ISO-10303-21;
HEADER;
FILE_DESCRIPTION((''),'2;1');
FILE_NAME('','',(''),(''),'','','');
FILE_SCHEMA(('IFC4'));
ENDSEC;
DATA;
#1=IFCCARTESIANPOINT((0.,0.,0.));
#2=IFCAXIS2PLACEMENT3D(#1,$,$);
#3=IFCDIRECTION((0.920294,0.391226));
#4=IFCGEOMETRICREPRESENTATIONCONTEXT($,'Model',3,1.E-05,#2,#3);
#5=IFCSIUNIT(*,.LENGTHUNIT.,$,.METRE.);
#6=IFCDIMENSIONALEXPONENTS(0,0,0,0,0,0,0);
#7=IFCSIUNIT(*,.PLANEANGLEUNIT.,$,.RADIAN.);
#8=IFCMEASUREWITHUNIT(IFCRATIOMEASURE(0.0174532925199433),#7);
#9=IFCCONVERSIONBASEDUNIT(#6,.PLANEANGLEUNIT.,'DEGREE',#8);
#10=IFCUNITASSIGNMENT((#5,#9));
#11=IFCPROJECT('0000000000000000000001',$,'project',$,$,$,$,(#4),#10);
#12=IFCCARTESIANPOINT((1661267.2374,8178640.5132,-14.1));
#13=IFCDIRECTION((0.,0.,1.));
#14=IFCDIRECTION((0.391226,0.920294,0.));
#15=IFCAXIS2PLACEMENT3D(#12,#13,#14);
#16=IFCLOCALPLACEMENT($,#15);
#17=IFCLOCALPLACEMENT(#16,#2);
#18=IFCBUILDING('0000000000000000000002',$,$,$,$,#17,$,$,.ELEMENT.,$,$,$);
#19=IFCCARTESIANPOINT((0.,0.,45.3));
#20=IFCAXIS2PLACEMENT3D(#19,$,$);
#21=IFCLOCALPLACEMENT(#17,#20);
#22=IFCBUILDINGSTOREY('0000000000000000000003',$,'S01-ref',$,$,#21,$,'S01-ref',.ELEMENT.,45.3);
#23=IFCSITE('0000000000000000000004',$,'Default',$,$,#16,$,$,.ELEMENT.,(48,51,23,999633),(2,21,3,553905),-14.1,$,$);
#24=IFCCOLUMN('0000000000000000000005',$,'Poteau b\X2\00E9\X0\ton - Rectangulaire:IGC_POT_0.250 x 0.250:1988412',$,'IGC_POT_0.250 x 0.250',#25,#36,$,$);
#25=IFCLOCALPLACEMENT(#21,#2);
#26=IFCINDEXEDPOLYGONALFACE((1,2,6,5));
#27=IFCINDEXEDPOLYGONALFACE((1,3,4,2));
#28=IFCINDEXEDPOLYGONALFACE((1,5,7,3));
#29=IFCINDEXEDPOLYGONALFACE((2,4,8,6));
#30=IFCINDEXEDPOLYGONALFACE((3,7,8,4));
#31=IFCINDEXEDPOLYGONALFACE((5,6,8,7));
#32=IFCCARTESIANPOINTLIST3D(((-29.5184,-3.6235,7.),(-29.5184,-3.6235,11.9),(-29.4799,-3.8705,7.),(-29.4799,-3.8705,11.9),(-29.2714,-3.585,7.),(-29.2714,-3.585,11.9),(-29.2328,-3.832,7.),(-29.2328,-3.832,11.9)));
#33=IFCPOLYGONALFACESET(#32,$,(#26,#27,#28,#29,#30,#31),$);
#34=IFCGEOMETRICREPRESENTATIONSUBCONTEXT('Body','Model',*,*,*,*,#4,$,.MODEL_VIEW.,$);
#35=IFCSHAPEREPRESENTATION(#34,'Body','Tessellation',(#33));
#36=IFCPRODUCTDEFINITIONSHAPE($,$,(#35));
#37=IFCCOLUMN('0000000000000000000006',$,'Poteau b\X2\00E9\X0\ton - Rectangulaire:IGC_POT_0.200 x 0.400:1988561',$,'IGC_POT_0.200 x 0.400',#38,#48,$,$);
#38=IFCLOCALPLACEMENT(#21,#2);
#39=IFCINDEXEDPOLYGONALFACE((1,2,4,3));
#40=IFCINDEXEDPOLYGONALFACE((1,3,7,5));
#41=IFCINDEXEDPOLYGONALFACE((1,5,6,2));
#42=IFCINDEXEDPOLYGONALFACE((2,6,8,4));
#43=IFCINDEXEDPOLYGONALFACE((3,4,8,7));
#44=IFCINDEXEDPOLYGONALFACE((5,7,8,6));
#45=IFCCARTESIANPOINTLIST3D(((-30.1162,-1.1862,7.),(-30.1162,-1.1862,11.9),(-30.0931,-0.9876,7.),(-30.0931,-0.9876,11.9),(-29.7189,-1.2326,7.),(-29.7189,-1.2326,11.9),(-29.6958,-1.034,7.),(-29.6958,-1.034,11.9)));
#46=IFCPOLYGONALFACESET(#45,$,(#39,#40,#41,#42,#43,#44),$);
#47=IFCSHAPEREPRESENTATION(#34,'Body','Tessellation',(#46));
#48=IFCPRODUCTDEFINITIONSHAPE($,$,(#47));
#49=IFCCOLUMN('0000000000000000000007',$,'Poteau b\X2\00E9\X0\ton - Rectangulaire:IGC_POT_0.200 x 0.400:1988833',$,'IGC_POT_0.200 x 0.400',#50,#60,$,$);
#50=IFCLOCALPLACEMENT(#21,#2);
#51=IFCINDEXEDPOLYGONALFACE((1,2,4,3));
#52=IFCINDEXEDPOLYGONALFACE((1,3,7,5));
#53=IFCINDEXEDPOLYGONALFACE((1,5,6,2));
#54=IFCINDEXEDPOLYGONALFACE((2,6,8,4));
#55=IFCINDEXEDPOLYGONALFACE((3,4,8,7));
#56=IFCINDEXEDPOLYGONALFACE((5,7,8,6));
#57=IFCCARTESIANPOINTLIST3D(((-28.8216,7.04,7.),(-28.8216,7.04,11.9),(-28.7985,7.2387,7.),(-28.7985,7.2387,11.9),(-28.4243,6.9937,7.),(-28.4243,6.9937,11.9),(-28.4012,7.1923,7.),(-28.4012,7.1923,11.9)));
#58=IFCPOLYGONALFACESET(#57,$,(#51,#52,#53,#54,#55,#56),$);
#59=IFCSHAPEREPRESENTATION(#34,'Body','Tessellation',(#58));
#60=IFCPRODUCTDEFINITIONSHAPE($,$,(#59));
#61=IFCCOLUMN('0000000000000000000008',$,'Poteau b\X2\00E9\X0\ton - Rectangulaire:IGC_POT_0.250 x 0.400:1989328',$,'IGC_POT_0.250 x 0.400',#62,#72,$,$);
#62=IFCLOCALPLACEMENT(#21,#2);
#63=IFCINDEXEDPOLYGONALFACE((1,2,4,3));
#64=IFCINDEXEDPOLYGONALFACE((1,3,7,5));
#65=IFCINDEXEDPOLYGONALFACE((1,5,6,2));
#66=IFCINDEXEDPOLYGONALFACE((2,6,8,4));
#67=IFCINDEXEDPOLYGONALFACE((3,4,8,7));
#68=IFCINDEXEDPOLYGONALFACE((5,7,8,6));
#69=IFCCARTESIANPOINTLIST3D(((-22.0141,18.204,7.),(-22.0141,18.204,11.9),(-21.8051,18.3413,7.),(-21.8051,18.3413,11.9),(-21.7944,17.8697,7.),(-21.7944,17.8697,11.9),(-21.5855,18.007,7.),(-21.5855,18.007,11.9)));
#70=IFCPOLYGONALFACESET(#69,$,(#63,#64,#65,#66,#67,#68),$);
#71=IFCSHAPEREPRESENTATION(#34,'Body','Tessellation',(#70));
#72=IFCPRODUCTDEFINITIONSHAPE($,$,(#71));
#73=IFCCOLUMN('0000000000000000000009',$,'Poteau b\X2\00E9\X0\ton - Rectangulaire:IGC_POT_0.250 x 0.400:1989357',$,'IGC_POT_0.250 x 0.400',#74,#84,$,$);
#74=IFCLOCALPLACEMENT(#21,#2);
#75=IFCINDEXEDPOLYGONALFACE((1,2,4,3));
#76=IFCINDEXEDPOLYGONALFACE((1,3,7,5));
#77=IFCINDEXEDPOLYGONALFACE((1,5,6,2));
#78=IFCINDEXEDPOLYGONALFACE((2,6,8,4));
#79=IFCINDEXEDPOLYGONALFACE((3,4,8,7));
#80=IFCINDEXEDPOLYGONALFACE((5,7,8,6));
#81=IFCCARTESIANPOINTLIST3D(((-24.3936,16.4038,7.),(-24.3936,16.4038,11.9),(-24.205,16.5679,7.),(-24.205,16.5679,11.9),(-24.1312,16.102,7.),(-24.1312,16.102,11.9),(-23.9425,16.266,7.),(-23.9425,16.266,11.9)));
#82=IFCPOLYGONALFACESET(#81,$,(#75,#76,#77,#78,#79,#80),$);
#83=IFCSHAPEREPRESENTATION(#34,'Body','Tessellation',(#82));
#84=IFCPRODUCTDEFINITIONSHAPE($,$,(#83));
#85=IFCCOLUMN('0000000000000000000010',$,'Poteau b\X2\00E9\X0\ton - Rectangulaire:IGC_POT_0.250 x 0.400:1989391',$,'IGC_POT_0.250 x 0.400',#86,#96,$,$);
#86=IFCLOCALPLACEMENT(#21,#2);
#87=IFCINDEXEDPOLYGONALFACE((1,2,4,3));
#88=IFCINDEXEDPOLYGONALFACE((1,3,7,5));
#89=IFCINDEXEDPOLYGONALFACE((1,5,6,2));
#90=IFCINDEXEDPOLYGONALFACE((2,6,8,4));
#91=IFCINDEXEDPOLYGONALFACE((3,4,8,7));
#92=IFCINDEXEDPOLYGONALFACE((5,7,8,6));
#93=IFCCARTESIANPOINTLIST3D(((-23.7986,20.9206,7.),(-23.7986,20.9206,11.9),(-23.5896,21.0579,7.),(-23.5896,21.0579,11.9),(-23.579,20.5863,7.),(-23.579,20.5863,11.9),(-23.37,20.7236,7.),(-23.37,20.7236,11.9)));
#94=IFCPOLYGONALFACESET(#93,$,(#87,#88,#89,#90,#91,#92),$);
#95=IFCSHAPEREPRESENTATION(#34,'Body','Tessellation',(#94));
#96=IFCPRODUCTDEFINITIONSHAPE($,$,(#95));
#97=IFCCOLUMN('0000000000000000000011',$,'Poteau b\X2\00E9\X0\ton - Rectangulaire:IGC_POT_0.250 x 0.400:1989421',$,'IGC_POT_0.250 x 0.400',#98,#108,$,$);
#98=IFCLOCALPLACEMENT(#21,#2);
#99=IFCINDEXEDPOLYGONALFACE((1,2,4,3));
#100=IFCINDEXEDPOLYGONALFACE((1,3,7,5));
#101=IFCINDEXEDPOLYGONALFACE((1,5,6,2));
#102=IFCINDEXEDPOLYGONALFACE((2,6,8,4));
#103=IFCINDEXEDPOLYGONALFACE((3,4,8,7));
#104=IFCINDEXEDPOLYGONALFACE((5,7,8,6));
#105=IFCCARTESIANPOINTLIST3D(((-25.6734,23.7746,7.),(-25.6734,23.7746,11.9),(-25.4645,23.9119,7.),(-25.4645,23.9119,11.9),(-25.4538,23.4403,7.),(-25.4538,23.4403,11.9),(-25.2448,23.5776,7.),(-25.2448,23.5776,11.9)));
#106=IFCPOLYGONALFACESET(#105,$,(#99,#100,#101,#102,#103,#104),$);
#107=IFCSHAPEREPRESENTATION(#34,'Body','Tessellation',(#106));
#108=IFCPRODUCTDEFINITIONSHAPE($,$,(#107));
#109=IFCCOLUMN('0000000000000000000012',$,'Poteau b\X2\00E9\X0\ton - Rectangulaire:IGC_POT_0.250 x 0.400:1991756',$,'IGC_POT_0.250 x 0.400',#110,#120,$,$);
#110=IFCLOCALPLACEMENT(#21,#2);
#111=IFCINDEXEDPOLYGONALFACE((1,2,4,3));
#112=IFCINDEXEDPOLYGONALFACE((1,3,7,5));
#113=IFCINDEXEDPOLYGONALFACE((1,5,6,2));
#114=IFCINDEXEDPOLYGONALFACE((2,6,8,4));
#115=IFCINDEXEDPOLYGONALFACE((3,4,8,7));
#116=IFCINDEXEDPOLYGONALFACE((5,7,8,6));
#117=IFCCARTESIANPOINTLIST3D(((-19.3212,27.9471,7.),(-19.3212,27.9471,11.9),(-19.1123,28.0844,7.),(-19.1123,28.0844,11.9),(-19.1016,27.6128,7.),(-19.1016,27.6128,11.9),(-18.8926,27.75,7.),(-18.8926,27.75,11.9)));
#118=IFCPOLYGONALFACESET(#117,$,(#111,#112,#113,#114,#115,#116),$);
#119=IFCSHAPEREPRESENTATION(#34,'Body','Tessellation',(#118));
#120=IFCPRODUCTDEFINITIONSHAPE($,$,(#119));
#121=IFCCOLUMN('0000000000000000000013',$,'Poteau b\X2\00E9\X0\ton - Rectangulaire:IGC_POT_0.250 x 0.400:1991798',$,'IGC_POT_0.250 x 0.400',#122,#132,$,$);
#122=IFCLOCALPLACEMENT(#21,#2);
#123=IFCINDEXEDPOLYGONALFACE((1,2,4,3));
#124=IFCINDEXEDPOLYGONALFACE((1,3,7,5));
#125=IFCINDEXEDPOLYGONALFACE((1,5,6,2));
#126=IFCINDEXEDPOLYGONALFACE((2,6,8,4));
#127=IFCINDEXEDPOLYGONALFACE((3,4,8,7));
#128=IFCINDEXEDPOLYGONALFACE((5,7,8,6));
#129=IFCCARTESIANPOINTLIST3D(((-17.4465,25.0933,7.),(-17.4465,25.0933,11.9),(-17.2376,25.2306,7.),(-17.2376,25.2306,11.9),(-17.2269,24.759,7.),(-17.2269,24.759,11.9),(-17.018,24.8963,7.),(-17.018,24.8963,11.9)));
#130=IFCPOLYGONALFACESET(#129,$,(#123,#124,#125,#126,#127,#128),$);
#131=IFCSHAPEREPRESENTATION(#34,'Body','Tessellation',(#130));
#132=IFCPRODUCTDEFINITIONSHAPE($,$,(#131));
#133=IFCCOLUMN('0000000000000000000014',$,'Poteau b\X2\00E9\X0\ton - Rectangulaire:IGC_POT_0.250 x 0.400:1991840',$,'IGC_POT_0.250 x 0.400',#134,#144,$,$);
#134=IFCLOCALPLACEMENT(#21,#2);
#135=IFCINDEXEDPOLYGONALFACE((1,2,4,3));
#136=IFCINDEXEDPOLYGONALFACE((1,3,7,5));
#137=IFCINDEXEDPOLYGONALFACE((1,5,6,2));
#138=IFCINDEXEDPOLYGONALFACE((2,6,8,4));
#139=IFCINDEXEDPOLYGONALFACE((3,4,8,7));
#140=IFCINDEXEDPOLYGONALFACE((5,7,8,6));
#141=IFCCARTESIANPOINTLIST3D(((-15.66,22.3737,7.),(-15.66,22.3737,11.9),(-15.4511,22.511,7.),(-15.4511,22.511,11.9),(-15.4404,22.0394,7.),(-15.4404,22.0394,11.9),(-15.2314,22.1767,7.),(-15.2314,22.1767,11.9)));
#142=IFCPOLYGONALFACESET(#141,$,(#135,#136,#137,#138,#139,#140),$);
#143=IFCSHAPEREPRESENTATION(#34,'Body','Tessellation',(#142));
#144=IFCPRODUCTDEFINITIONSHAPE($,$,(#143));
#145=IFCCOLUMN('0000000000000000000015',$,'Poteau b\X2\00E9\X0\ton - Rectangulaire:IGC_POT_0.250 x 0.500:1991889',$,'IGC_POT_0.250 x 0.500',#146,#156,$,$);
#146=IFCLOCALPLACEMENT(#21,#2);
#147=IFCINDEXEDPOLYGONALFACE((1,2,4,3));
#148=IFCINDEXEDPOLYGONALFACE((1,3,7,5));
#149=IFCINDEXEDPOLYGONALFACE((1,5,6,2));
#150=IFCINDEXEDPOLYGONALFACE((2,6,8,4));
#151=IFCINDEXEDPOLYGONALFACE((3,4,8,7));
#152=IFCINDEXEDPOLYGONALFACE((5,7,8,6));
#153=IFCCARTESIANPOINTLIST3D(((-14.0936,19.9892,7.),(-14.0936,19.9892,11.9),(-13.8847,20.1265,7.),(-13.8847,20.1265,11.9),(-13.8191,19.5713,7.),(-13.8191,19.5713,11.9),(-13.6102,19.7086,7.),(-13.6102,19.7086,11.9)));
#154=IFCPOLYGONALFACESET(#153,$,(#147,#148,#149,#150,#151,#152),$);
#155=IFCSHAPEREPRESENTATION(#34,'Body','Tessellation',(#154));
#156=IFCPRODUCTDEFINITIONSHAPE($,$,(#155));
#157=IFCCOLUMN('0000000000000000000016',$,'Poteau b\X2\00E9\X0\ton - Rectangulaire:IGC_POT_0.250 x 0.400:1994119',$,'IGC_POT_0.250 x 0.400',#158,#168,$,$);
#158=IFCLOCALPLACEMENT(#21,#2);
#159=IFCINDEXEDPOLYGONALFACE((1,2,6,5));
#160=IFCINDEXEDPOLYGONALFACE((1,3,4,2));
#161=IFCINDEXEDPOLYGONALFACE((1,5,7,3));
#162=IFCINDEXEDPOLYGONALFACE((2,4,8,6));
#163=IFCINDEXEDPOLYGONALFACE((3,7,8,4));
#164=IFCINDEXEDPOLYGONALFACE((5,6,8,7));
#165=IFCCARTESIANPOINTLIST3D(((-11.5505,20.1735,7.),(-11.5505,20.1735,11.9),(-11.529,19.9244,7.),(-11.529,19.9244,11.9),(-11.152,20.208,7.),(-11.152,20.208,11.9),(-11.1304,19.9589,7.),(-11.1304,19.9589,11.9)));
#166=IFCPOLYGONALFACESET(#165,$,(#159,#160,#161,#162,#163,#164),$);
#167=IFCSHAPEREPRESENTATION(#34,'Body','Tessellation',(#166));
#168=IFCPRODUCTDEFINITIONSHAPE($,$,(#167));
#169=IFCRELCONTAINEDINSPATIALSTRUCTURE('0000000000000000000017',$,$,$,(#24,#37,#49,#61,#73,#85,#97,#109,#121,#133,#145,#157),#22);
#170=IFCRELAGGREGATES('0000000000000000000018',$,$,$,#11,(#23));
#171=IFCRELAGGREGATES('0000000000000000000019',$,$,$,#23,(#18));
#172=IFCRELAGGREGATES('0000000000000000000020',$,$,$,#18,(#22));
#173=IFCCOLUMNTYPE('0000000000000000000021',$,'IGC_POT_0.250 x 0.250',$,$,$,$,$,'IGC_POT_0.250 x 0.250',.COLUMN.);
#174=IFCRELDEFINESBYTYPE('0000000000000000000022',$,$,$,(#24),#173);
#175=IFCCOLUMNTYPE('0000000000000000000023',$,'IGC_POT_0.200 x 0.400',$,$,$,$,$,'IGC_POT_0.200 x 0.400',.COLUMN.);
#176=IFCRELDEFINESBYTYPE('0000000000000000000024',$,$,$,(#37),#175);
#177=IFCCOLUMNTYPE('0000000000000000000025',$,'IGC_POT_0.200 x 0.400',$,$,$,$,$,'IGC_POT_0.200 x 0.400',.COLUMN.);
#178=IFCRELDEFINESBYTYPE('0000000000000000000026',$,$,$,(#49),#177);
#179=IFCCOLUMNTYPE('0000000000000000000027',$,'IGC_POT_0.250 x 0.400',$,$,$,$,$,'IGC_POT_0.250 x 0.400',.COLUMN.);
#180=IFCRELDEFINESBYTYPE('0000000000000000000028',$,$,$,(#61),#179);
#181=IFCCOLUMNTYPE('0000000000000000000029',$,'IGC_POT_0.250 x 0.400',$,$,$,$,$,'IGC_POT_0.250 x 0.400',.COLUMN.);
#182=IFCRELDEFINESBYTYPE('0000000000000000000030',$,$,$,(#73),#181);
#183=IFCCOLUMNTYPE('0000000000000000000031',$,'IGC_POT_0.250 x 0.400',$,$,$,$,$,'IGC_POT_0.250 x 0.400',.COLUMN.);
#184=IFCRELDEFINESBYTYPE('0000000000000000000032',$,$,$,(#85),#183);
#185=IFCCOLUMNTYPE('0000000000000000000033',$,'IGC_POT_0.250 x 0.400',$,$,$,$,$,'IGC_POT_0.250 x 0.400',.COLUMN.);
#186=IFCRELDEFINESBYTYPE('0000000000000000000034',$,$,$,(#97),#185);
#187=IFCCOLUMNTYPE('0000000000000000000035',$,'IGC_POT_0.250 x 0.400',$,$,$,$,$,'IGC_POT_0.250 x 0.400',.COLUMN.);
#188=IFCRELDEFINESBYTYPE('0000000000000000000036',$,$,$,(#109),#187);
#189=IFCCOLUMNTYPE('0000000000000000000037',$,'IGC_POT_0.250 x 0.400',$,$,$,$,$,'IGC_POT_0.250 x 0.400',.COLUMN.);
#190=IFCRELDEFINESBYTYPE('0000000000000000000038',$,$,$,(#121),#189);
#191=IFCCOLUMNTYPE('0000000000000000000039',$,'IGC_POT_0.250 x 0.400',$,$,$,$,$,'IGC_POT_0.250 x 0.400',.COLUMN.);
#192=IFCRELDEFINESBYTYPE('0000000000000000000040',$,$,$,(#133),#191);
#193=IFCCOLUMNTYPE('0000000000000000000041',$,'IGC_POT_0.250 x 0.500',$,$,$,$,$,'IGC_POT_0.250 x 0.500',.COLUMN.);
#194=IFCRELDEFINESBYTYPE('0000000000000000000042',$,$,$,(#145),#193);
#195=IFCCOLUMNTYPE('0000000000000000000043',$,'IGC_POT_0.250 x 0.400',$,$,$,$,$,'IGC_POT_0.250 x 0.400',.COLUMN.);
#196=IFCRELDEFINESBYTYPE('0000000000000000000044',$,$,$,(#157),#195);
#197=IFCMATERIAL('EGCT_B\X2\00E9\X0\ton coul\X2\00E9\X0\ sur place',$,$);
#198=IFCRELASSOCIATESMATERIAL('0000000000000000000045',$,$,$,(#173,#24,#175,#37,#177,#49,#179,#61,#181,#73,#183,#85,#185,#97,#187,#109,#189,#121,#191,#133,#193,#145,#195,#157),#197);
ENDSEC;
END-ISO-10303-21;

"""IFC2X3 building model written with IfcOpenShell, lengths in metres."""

from ifc_helpers import new_model, entity, si_unit, converted_unit, direction, frame, frame_2d, origin, origin_2d_with_axis, place, context, subcontext, project, spatial, rectangle, extrude, source, transform, mapped, material, type_object, type_shapes, element, save


model = new_model("IFC2X3")

# Units and contexts
model_context = context("Model", 3, precision=1e-05, world=origin(), true_north=direction((0.920294, 0.391226)))
body_context = subcontext(model_context, "Body", "Model", "MODEL_VIEW")
ifc_project = project(units=[si_unit("LENGTHUNIT", "METRE"), converted_unit("PLANEANGLEUNIT", "DEGREE", entity("IfcRatioMeasure", 0.0174532925199433), si_unit("PLANEANGLEUNIT", "RADIAN"), dimensions=[0, 0, 0, 0, 0, 0, 0])], contexts=[model_context])

# Site, building, storey
site_placement = place(None, frame((1661267.2374, 8178640.5132, -14.1), z_axis=(0.0, 0.0, 1.0), x_axis=(0.391226, 0.920294, 0.0)))
site = spatial("IfcSite", under=ifc_project, at=site_placement, Name="Default", CompositionType="ELEMENT", RefLatitude=(48, 51, 23, 999633), RefLongitude=(2, 21, 3, 553905), RefElevation=-14.1)
building_placement = place(site_placement, origin())
building = spatial("IfcBuilding", under=site, at=building_placement, CompositionType="ELEMENT")
storey_placement = place(building_placement, frame((0.0, 0.0, 45.3)))
storey = spatial("IfcBuildingStorey", under=building, at=storey_placement, Name="S01-ref", LongName="S01-ref", CompositionType="ELEMENT", Elevation=45.3)

# Columns
ifc_material_1 = material(Name="EGCT_Béton coulé sur place")
column_type_1 = type_object("IfcColumnType", Name="IGC_POT_0.250 x 0.250", ElementType="IGC_POT_0.250 x 0.250", PredefinedType="COLUMN", material=ifc_material_1)
shared_shape_1 = source(origin(), body_context, "Body", "SweptSolid", [
    extrude(rectangle(XDim=0.25, YDim=0.25, at=frame_2d((0.0, 0.0), x_axis=(1.0, 0.0))), frame((-29.3756, -3.7278, 52.3), z_axis=(0.0, 0.0, 1.0), x_axis=(-0.15408, 0.988058, 0.0)), (0.0, 0.0, 1.0), 4.9),
])
type_shapes(column_type_1, [shared_shape_1])
column_1_placement = place(storey_placement, frame((0.0, 0.0, -45.3)))
element("IfcColumn", 1, at=column_1_placement, inside=storey, type_object=column_type_1, material=ifc_material_1, Name="Poteau béton - Rectangulaire:IGC_POT_0.250 x 0.250:1988412", ObjectType="IGC_POT_0.250 x 0.250", context=body_context, shape_type="MappedRepresentation", body=[
    mapped(shared_shape_1, transform((0.0, 0.0, 0.0), scale=1.0)),
])
column_type_2 = type_object("IfcColumnType", Name="IGC_POT_0.200 x 0.400", ElementType="IGC_POT_0.200 x 0.400", PredefinedType="COLUMN", material=ifc_material_1)
shared_shape_2 = source(origin(), body_context, "Body", "SweptSolid", [
    extrude(rectangle(XDim=0.4, YDim=0.2, at=frame_2d((0.0, 0.0), x_axis=(1.0, 0.0))), frame((-29.906, -1.1101, 52.3), z_axis=(0.0, 0.0, 1.0), x_axis=(-0.993261, 0.115901, 0.0)), (0.0, 0.0, 1.0), 4.9),
])
type_shapes(column_type_2, [shared_shape_2])
column_2_placement = place(storey_placement, frame((0.0, 0.0, -45.3)))
element("IfcColumn", 2, at=column_2_placement, inside=storey, type_object=column_type_2, material=ifc_material_1, Name="Poteau béton - Rectangulaire:IGC_POT_0.200 x 0.400:1988561", ObjectType="IGC_POT_0.200 x 0.400", context=body_context, shape_type="MappedRepresentation", body=[
    mapped(shared_shape_2, transform((0.0, 0.0, 0.0), scale=1.0)),
])
column_type_3 = type_object("IfcColumnType", Name="IGC_POT_0.200 x 0.400", ElementType="IGC_POT_0.200 x 0.400", PredefinedType="COLUMN", material=ifc_material_1)
shared_shape_3 = source(origin(), body_context, "Body", "SweptSolid", [
    extrude(rectangle(XDim=0.4, YDim=0.2, at=frame_2d((0.0, 0.0), x_axis=(1.0, 0.0))), frame((-28.6114, 7.1162, 52.3), z_axis=(0.0, 0.0, 1.0), x_axis=(-0.993261, 0.115901, 0.0)), (0.0, 0.0, 1.0), 4.9),
])
type_shapes(column_type_3, [shared_shape_3])
column_3_placement = place(storey_placement, frame((0.0, 0.0, -45.3)))
element("IfcColumn", 3, at=column_3_placement, inside=storey, type_object=column_type_3, material=ifc_material_1, Name="Poteau béton - Rectangulaire:IGC_POT_0.200 x 0.400:1988833", ObjectType="IGC_POT_0.200 x 0.400", context=body_context, shape_type="MappedRepresentation", body=[
    mapped(shared_shape_3, transform((0.0, 0.0, 0.0), scale=1.0)),
])
column_type_4 = type_object("IfcColumnType", Name="IGC_POT_0.250 x 0.400", ElementType="IGC_POT_0.250 x 0.400", PredefinedType="COLUMN", material=ifc_material_1)
shared_shape_4 = source(origin(), body_context, "Body", "SweptSolid", [
    extrude(rectangle(XDim=0.4, YDim=0.25, at=frame_2d((0.0, 0.0), x_axis=(1.0, 0.0))), frame((-21.7998, 18.1055, 52.3), z_axis=(0.0, 0.0, 1.0), x_axis=(-0.549039, 0.835797, 0.0)), (0.0, 0.0, 1.0), 4.9),
])
type_shapes(column_type_4, [shared_shape_4])
column_4_placement = place(storey_placement, frame((0.0, 0.0, -45.3)))
element("IfcColumn", 4, at=column_4_placement, inside=storey, type_object=column_type_4, material=ifc_material_1, Name="Poteau béton - Rectangulaire:IGC_POT_0.250 x 0.400:1989328", ObjectType="IGC_POT_0.250 x 0.400", context=body_context, shape_type="MappedRepresentation", body=[
    mapped(shared_shape_4, transform((0.0, 0.0, 0.0), scale=1.0)),
])
column_type_5 = type_object("IfcColumnType", Name="IGC_POT_0.250 x 0.400", ElementType="IGC_POT_0.250 x 0.400", PredefinedType="COLUMN", material=ifc_material_1)
shared_shape_5 = source(origin(), body_context, "Body", "SweptSolid", [
    extrude(rectangle(XDim=0.4, YDim=0.25, at=frame_2d((0.0, 0.0), x_axis=(1.0, 0.0))), frame((-24.1681, 16.3349, 52.3), z_axis=(0.0, 0.0, 1.0), x_axis=(-0.656059, 0.75471, 0.0)), (0.0, 0.0, 1.0), 4.9),
])
type_shapes(column_type_5, [shared_shape_5])
column_5_placement = place(storey_placement, frame((0.0, 0.0, -45.3)))
element("IfcColumn", 5, at=column_5_placement, inside=storey, type_object=column_type_5, material=ifc_material_1, Name="Poteau béton - Rectangulaire:IGC_POT_0.250 x 0.400:1989357", ObjectType="IGC_POT_0.250 x 0.400", context=body_context, shape_type="MappedRepresentation", body=[
    mapped(shared_shape_5, transform((0.0, 0.0, 0.0), scale=1.0)),
])
column_type_6 = type_object("IfcColumnType", Name="IGC_POT_0.250 x 0.400", ElementType="IGC_POT_0.250 x 0.400", PredefinedType="COLUMN", material=ifc_material_1)
shared_shape_6 = source(origin(), body_context, "Body", "SweptSolid", [
    extrude(rectangle(XDim=0.4, YDim=0.25, at=frame_2d((0.0, 0.0), x_axis=(1.0, 0.0))), frame((-23.5843, 20.8221, 52.3), z_axis=(0.0, 0.0, 1.0), x_axis=(-0.549039, 0.835797, 0.0)), (0.0, 0.0, 1.0), 4.9),
])
type_shapes(column_type_6, [shared_shape_6])
column_6_placement = place(storey_placement, frame((0.0, 0.0, -45.3)))
element("IfcColumn", 6, at=column_6_placement, inside=storey, type_object=column_type_6, material=ifc_material_1, Name="Poteau béton - Rectangulaire:IGC_POT_0.250 x 0.400:1989391", ObjectType="IGC_POT_0.250 x 0.400", context=body_context, shape_type="MappedRepresentation", body=[
    mapped(shared_shape_6, transform((0.0, 0.0, 0.0), scale=1.0)),
])
column_type_7 = type_object("IfcColumnType", Name="IGC_POT_0.250 x 0.400", ElementType="IGC_POT_0.250 x 0.400", PredefinedType="COLUMN", material=ifc_material_1)
shared_shape_7 = source(origin(), body_context, "Body", "SweptSolid", [
    extrude(rectangle(XDim=0.4, YDim=0.25, at=frame_2d((0.0, 0.0), x_axis=(1.0, 0.0))), frame((-25.4591, 23.6761, 52.3), z_axis=(0.0, 0.0, 1.0), x_axis=(-0.549039, 0.835797, 0.0)), (0.0, 0.0, 1.0), 4.9),
])
type_shapes(column_type_7, [shared_shape_7])
column_7_placement = place(storey_placement, frame((0.0, 0.0, -45.3)))
element("IfcColumn", 7, at=column_7_placement, inside=storey, type_object=column_type_7, material=ifc_material_1, Name="Poteau béton - Rectangulaire:IGC_POT_0.250 x 0.400:1989421", ObjectType="IGC_POT_0.250 x 0.400", context=body_context, shape_type="MappedRepresentation", body=[
    mapped(shared_shape_7, transform((0.0, 0.0, 0.0), scale=1.0)),
])
column_type_8 = type_object("IfcColumnType", Name="IGC_POT_0.250 x 0.400", ElementType="IGC_POT_0.250 x 0.400", PredefinedType="COLUMN", material=ifc_material_1)
shared_shape_8 = source(origin(), body_context, "Body", "SweptSolid", [
    extrude(rectangle(XDim=0.4, YDim=0.25, at=frame_2d((0.0, 0.0), x_axis=(1.0, 0.0))), frame((-19.1069, 27.8486, 52.3), z_axis=(0.0, 0.0, 1.0), x_axis=(-0.549039, 0.835797, 0.0)), (0.0, 0.0, 1.0), 4.9),
])
type_shapes(column_type_8, [shared_shape_8])
column_8_placement = place(storey_placement, frame((0.0, 0.0, -45.3)))
element("IfcColumn", 8, at=column_8_placement, inside=storey, type_object=column_type_8, material=ifc_material_1, Name="Poteau béton - Rectangulaire:IGC_POT_0.250 x 0.400:1991756", ObjectType="IGC_POT_0.250 x 0.400", context=body_context, shape_type="MappedRepresentation", body=[
    mapped(shared_shape_8, transform((0.0, 0.0, 0.0), scale=1.0)),
])
column_type_9 = type_object("IfcColumnType", Name="IGC_POT_0.250 x 0.400", ElementType="IGC_POT_0.250 x 0.400", PredefinedType="COLUMN", material=ifc_material_1)
shared_shape_9 = source(origin(), body_context, "Body", "SweptSolid", [
    extrude(rectangle(XDim=0.4, YDim=0.25, at=frame_2d((0.0, 0.0), x_axis=(1.0, 0.0))), frame((-17.2322, 24.9948, 52.3), z_axis=(0.0, 0.0, 1.0), x_axis=(-0.549039, 0.835797, 0.0)), (0.0, 0.0, 1.0), 4.9),
])
type_shapes(column_type_9, [shared_shape_9])
column_9_placement = place(storey_placement, frame((0.0, 0.0, -45.3)))
element("IfcColumn", 9, at=column_9_placement, inside=storey, type_object=column_type_9, material=ifc_material_1, Name="Poteau béton - Rectangulaire:IGC_POT_0.250 x 0.400:1991798", ObjectType="IGC_POT_0.250 x 0.400", context=body_context, shape_type="MappedRepresentation", body=[
    mapped(shared_shape_9, transform((0.0, 0.0, 0.0), scale=1.0)),
])
column_type_10 = type_object("IfcColumnType", Name="IGC_POT_0.250 x 0.400", ElementType="IGC_POT_0.250 x 0.400", PredefinedType="COLUMN", material=ifc_material_1)
shared_shape_10 = source(origin(), body_context, "Body", "SweptSolid", [
    extrude(rectangle(XDim=0.4, YDim=0.25, at=origin_2d_with_axis()), frame((-15.4457, 22.2752, 52.3), z_axis=(0.0, 0.0, 1.0), x_axis=(-0.549039, 0.835797, 0.0)), (0.0, 0.0, 1.0), 4.9),
])
type_shapes(column_type_10, [shared_shape_10])
column_10_placement = place(storey_placement, frame((0.0, 0.0, -45.3)))
element("IfcColumn", 10, at=column_10_placement, inside=storey, type_object=column_type_10, material=ifc_material_1, Name="Poteau béton - Rectangulaire:IGC_POT_0.250 x 0.400:1991840", ObjectType="IGC_POT_0.250 x 0.400", context=body_context, shape_type="MappedRepresentation", body=[
    mapped(shared_shape_10, transform((0.0, 0.0, 0.0), scale=1.0)),
])
column_type_11 = type_object("IfcColumnType", Name="IGC_POT_0.250 x 0.500", ElementType="IGC_POT_0.250 x 0.500", PredefinedType="COLUMN", material=ifc_material_1)
shared_shape_11 = source(origin(), body_context, "Body", "SweptSolid", [
    extrude(rectangle(XDim=0.5, YDim=0.25, at=frame_2d((0.0, 0.0), x_axis=(1.0, 0.0))), frame((-13.8519, 19.8489, 52.3), z_axis=(0.0, 0.0, 1.0), x_axis=(-0.549039, 0.835797, 0.0)), (0.0, 0.0, 1.0), 4.9),
])
type_shapes(column_type_11, [shared_shape_11])
column_11_placement = place(storey_placement, frame((0.0, 0.0, -45.3)))
element("IfcColumn", 11, at=column_11_placement, inside=storey, type_object=column_type_11, material=ifc_material_1, Name="Poteau béton - Rectangulaire:IGC_POT_0.250 x 0.500:1991889", ObjectType="IGC_POT_0.250 x 0.500", context=body_context, shape_type="MappedRepresentation", body=[
    mapped(shared_shape_11, transform((0.0, 0.0, 0.0), scale=1.0)),
])
column_type_12 = type_object("IfcColumnType", Name="IGC_POT_0.250 x 0.400", ElementType="IGC_POT_0.250 x 0.400", PredefinedType="COLUMN", material=ifc_material_1)
shared_shape_12 = source(origin(), body_context, "Body", "SweptSolid", [
    extrude(rectangle(XDim=0.25, YDim=0.4, at=origin_2d_with_axis()), frame((-11.3405, 20.0662, 52.3), z_axis=(0.0, 0.0, 1.0), x_axis=(-0.086199, 0.996278, 0.0)), (0.0, 0.0, 1.0), 4.9),
])
type_shapes(column_type_12, [shared_shape_12])
column_12_placement = place(storey_placement, frame((0.0, 0.0, -45.3)))
element("IfcColumn", 12, at=column_12_placement, inside=storey, type_object=column_type_12, material=ifc_material_1, Name="Poteau béton - Rectangulaire:IGC_POT_0.250 x 0.400:1994119", ObjectType="IGC_POT_0.250 x 0.400", context=body_context, shape_type="MappedRepresentation", body=[
    mapped(shared_shape_12, transform((0.0, 0.0, 0.0), scale=1.0)),
])

save(model, "model.ifc")
